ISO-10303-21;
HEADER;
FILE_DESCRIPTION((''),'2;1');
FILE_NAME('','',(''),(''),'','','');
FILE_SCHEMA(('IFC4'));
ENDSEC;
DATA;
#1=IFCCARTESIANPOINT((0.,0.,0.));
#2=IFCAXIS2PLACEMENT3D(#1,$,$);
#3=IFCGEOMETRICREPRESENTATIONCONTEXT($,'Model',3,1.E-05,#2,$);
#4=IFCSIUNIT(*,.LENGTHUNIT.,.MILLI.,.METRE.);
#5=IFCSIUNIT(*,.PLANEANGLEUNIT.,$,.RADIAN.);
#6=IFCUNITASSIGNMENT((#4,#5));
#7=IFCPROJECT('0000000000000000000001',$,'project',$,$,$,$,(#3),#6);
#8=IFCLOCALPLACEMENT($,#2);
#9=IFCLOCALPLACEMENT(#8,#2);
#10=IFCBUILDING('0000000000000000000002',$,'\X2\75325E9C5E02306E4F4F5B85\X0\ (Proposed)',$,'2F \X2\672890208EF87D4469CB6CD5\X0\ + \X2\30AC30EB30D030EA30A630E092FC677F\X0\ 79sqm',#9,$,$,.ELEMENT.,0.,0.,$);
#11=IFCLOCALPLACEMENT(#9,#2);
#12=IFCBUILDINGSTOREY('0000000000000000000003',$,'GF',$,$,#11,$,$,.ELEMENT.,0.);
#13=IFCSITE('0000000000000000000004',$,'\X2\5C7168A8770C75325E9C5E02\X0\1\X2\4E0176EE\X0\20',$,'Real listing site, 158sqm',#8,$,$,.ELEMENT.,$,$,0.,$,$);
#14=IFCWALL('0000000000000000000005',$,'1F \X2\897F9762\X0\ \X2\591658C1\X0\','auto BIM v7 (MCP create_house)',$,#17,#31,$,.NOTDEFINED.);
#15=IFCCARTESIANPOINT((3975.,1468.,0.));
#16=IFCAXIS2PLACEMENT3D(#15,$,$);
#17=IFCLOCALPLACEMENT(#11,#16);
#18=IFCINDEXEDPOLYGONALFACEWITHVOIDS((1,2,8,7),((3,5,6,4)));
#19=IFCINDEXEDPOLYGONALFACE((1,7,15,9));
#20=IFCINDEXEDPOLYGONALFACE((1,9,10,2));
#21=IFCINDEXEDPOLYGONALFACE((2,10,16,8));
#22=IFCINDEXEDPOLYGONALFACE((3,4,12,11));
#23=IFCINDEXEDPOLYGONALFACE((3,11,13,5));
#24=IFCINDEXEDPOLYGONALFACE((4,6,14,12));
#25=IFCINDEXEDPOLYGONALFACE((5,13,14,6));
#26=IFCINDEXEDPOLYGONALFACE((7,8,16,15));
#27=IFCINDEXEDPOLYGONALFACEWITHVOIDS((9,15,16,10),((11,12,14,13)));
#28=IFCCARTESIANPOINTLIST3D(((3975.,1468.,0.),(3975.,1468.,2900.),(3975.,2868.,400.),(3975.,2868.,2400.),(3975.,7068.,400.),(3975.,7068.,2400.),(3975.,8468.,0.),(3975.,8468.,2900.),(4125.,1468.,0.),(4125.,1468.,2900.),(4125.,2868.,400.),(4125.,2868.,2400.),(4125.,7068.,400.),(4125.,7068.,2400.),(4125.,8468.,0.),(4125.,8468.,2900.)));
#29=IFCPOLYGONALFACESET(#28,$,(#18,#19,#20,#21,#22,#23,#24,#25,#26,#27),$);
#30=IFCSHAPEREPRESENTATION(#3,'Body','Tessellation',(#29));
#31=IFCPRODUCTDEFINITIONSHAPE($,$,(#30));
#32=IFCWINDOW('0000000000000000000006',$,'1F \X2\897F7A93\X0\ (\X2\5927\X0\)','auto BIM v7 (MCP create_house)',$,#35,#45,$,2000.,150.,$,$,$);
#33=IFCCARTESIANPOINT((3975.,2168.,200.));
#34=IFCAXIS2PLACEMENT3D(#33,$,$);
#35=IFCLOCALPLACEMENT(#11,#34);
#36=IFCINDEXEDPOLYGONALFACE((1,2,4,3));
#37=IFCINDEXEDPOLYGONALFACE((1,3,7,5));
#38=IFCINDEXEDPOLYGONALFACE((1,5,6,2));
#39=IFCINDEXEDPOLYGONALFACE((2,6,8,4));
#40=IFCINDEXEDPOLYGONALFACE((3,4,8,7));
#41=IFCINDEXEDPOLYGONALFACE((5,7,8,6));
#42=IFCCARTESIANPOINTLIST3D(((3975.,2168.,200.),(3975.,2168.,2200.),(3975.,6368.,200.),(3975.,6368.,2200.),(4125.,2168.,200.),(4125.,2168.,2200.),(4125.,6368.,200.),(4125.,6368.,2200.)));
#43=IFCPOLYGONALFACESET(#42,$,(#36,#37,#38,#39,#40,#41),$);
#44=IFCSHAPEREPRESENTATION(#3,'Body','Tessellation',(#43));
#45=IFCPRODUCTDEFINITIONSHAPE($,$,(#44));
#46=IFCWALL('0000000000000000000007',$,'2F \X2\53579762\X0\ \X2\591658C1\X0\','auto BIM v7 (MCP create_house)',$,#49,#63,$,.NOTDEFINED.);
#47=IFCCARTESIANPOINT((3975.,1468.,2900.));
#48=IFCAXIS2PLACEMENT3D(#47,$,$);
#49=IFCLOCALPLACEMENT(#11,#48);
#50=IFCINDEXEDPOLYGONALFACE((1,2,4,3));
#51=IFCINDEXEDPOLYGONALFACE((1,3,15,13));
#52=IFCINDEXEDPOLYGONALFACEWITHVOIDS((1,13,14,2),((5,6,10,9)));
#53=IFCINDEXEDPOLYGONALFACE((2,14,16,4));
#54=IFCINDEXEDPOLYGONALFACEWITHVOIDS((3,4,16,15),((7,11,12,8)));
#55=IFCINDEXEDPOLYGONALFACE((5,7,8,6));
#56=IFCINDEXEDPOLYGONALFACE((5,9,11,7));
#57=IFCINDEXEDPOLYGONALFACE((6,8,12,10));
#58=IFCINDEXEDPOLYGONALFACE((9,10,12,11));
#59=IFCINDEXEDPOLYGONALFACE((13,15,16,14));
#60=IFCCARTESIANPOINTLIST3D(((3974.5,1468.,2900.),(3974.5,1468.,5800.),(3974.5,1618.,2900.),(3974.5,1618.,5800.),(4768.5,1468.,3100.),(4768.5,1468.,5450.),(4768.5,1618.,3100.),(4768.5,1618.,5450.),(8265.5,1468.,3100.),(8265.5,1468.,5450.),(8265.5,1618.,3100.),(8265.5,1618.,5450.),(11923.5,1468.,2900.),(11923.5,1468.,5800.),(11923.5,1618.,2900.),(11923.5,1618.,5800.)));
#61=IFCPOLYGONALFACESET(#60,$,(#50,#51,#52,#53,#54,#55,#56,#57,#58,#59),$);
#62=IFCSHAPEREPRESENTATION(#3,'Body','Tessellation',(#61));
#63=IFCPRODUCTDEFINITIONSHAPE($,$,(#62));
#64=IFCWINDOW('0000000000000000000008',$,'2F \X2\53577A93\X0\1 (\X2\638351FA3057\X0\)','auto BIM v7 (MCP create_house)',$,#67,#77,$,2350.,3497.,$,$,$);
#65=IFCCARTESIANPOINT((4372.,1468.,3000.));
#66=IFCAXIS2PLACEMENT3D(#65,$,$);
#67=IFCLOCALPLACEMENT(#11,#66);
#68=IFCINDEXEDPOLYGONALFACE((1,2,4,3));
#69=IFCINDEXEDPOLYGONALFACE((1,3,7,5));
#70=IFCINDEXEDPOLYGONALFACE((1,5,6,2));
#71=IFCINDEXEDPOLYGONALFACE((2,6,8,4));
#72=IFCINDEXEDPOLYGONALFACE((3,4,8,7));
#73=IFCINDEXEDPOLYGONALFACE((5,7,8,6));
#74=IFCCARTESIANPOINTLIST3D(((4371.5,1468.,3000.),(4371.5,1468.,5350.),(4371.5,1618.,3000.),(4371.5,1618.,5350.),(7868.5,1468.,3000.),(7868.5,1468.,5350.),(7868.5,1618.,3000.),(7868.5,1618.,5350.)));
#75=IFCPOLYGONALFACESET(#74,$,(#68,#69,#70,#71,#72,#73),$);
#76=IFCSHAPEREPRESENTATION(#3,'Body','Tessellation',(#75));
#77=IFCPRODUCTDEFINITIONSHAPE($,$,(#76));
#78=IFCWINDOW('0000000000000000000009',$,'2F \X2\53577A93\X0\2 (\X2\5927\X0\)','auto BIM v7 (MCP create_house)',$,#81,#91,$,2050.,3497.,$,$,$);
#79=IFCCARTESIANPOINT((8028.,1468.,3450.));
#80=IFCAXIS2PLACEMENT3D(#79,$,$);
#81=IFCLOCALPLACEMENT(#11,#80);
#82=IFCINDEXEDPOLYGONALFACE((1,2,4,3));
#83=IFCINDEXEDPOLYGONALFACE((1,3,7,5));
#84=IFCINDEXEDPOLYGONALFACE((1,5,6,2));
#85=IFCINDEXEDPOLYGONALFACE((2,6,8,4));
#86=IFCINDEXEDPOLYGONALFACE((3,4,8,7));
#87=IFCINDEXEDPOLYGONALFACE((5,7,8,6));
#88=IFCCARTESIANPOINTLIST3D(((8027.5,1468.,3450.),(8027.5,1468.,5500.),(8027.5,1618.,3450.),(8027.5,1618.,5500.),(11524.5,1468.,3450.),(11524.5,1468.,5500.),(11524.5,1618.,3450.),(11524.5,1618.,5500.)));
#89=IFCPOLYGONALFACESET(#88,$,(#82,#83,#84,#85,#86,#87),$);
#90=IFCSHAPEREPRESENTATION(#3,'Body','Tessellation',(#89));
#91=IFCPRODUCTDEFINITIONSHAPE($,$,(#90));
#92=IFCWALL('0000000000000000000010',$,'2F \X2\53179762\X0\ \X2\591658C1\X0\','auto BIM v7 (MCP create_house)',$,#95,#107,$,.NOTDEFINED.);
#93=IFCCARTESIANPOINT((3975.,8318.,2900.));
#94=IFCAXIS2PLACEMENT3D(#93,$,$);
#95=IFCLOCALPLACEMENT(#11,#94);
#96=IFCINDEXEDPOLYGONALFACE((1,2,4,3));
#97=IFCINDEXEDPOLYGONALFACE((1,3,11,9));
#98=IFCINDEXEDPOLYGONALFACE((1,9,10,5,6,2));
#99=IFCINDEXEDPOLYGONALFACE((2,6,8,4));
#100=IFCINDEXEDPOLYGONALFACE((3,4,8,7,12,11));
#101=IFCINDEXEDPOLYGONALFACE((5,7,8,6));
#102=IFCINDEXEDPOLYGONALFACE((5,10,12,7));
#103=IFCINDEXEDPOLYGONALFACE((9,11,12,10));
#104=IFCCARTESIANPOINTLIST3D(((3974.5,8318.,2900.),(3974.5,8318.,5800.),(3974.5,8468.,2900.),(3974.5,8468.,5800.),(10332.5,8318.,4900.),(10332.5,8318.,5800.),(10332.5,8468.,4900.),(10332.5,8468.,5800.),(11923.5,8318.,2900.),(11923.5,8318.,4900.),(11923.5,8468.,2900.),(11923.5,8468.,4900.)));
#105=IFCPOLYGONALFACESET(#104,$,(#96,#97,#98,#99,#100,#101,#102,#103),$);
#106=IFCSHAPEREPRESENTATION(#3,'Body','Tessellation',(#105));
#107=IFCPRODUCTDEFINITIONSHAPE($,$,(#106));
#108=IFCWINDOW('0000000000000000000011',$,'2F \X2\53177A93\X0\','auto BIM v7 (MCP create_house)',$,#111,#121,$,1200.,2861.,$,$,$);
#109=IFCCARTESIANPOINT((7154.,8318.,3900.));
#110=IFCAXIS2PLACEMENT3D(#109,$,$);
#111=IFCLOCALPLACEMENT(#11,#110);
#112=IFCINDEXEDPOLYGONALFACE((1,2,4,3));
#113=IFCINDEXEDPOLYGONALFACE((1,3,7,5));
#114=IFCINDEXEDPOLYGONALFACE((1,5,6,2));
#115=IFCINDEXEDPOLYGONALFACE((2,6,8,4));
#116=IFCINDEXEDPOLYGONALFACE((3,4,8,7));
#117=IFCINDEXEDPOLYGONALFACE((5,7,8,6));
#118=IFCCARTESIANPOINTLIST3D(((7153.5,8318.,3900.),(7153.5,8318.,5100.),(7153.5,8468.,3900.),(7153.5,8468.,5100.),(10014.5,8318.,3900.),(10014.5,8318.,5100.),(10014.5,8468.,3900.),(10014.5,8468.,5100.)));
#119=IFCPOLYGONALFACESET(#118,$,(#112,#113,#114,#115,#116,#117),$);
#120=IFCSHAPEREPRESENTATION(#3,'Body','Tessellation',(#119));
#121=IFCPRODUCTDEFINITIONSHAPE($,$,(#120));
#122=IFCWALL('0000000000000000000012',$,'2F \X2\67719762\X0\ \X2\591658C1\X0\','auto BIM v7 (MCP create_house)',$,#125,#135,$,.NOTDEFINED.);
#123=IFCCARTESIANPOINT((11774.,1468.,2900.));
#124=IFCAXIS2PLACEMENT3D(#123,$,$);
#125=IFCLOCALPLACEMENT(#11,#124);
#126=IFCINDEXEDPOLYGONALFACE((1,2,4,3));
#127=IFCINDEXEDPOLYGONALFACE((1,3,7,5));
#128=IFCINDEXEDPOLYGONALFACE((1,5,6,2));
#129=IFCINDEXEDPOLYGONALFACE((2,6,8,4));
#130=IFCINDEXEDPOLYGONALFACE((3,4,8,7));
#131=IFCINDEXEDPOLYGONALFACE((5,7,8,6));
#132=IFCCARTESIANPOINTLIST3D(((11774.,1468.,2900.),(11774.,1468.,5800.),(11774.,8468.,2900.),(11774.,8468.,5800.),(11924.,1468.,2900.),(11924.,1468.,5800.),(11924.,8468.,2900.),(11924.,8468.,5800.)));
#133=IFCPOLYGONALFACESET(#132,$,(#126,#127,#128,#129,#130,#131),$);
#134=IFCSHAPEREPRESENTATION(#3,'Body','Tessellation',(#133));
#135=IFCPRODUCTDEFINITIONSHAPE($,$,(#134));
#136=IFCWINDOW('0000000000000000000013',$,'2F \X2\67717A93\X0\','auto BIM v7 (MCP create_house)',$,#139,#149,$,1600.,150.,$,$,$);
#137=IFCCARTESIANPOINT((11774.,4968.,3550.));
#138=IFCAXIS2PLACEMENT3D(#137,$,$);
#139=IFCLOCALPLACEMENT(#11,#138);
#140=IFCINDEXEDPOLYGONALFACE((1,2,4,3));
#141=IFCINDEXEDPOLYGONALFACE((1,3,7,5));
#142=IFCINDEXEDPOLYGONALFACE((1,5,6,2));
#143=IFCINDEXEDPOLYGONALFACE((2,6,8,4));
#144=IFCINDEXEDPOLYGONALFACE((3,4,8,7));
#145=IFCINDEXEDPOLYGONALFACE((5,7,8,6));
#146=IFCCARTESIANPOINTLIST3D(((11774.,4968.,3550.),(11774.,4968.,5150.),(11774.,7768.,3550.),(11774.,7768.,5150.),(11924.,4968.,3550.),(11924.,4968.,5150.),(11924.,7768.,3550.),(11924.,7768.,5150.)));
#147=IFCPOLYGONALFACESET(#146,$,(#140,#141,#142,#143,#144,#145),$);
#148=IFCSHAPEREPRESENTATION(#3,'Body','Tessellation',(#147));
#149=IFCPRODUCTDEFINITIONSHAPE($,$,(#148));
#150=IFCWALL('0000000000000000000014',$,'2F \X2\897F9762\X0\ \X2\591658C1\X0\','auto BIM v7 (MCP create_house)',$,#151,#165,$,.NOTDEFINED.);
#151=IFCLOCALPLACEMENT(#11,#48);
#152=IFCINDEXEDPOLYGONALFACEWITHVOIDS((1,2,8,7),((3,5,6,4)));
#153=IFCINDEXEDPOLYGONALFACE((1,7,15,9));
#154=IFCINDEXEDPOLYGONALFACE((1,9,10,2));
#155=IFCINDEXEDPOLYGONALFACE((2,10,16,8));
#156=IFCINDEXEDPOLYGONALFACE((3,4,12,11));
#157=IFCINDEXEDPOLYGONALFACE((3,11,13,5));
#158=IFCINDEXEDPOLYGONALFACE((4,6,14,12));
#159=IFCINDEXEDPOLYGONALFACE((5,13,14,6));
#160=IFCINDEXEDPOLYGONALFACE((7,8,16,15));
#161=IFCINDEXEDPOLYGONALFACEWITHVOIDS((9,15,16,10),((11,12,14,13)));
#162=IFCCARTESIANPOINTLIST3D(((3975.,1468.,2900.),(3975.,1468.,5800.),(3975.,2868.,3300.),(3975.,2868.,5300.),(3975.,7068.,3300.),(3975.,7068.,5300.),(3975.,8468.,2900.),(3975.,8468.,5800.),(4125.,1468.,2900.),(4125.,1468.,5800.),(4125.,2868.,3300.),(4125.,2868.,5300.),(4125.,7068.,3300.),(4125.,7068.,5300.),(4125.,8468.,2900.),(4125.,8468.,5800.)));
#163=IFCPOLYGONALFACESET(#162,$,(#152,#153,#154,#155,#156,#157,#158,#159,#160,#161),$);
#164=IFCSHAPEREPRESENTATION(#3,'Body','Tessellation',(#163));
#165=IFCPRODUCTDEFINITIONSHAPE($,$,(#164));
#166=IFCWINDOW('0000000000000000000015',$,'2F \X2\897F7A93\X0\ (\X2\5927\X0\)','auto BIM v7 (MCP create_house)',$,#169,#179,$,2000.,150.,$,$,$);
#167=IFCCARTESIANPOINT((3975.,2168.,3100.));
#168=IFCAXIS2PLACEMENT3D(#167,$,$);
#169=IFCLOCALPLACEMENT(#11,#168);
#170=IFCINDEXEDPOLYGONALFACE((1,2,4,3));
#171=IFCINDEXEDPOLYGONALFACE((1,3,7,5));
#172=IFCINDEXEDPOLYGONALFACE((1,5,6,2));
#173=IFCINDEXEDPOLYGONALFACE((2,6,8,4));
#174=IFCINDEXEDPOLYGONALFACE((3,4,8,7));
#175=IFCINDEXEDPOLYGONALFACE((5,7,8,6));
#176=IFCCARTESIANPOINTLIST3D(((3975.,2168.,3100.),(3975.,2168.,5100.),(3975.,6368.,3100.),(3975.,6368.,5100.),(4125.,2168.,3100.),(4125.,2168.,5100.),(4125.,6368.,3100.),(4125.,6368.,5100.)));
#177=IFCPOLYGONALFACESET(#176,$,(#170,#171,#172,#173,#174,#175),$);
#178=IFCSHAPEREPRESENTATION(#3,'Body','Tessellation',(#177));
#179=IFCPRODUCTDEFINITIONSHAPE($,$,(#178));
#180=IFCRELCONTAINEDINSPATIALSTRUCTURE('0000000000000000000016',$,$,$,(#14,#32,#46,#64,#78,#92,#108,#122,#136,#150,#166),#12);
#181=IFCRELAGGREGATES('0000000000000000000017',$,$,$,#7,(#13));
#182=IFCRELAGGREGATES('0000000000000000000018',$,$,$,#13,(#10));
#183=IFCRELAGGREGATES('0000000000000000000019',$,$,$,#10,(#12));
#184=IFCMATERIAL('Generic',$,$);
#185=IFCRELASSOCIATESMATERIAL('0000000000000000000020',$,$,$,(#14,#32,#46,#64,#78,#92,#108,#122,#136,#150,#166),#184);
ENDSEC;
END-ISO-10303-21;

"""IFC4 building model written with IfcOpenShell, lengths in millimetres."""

from ifc_helpers import new_model, si_unit, frame, frame_2d, origin, place, context, project, spatial, rectangle, extrude, material, element, fill, save


model = new_model("IFC4")

# Units and contexts
model_context = context("Model", 3, precision=1e-05, world=origin())
ifc_project = project(units=[si_unit("LENGTHUNIT", "METRE", prefix="MILLI"), si_unit("PLANEANGLEUNIT", "RADIAN")], contexts=[model_context])

# Site, building, storey
site_placement = place(None, origin())
site = spatial("IfcSite", under=ifc_project, at=site_placement, Name="山梨県甲府市1丁目20", ObjectType="Real listing site, 158sqm", CompositionType="ELEMENT", RefElevation=0.0)
building_placement = place(site_placement, origin())
building = spatial("IfcBuilding", under=site, at=building_placement, Name="甲府市の住宅 (Proposed)", ObjectType="2F 木造軸組構法 + ガルバリウム鋼板 79sqm", CompositionType="ELEMENT", ElevationOfRefHeight=0.0, ElevationOfTerrain=0.0)
storey_placement = place(building_placement, origin())
storey = spatial("IfcBuildingStorey", under=building, at=storey_placement, Name="GF", CompositionType="ELEMENT", Elevation=0.0)

# Shared definitions
ifc_material = material(Name="Generic")

# Wall, opening, window
wall_1_placement = place(storey_placement, frame((3975.0, 1468.0, 0.0)))
wall_1 = element("IfcWall", 1, at=wall_1_placement, inside=storey, material=ifc_material, Name="1F 西面 外壁", Description="auto BIM v7 (MCP create_house)", PredefinedType="NOTDEFINED", context=model_context, shape_type="SweptSolid", body=[
    extrude(rectangle(XDim=150.0, YDim=7000.0, at=frame_2d((75.0, 3500.0))), frame((3975.0, 1468.0, 0.0)), (0.0, 0.0, 1.0), 2900.0),
])
opening_1_placement = place(storey_placement, frame((3975.0, 2168.0, 200.0)))
opening_1 = element("IfcOpeningElement", 2, at=opening_1_placement, cuts=wall_1, PredefinedType="NOTDEFINED", context=model_context, shape_type="SweptSolid", body=[
    extrude(rectangle(XDim=150.0, YDim=4200.0, at=frame_2d((75.0, 2100.0))), frame((3975.0, 2168.0, 200.0)), (0.0, 0.0, 1.0), 2000.0),
])
window_1_placement = place(storey_placement, frame((3975.0, 2168.0, 200.0)))
window_1 = element("IfcWindow", 3, at=window_1_placement, inside=storey, material=ifc_material, Name="1F 西窓 (大)", Description="auto BIM v7 (MCP create_house)", OverallHeight=2000.0, OverallWidth=150.0, context=model_context, shape_type="SweptSolid", body=[
    extrude(rectangle(XDim=150.0, YDim=4200.0, at=frame_2d((75.0, 2100.0))), frame((3975.0, 2168.0, 200.0)), (0.0, 0.0, 1.0), 2000.0),
])
fill(opening_1, window_1)

# Wall, openings, windows
wall_2_placement = place(storey_placement, frame((3975.0, 1468.0, 2900.0)))
wall_2 = element("IfcWall", 4, at=wall_2_placement, inside=storey, material=ifc_material, Name="2F 南面 外壁", Description="auto BIM v7 (MCP create_house)", PredefinedType="NOTDEFINED", context=model_context, shape_type="SweptSolid", body=[
    extrude(rectangle(XDim=7949.0, YDim=150.0, at=frame_2d((3974.0, 75.0))), frame((3975.0, 1468.0, 2900.0)), (0.0, 0.0, 1.0), 2900.0),
])
opening_2_placement = place(storey_placement, frame((4372.0, 1468.0, 3000.0)))
opening_2 = element("IfcOpeningElement", 5, at=opening_2_placement, cuts=wall_2, PredefinedType="NOTDEFINED", context=model_context, shape_type="SweptSolid", body=[
    extrude(rectangle(XDim=3497.0, YDim=150.0, at=frame_2d((1748.0, 75.0))), frame((4372.0, 1468.0, 3000.0)), (0.0, 0.0, 1.0), 2350.0),
])
opening_3_placement = place(storey_placement, frame((8028.0, 1468.0, 3450.0)))
opening_3 = element("IfcOpeningElement", 6, at=opening_3_placement, cuts=wall_2, PredefinedType="NOTDEFINED", context=model_context, shape_type="SweptSolid", body=[
    extrude(rectangle(XDim=3497.0, YDim=150.0, at=frame_2d((1748.0, 75.0))), frame((8028.0, 1468.0, 3450.0)), (0.0, 0.0, 1.0), 2050.0),
])
window_2_placement = place(storey_placement, frame((4372.0, 1468.0, 3000.0)))
window_2 = element("IfcWindow", 7, at=window_2_placement, inside=storey, material=ifc_material, Name="2F 南窓1 (掃出し)", Description="auto BIM v7 (MCP create_house)", OverallHeight=2350.0, OverallWidth=3497.0, context=model_context, shape_type="SweptSolid", body=[
    extrude(rectangle(XDim=3497.0, YDim=150.0, at=frame_2d((1748.0, 75.0))), frame((4372.0, 1468.0, 3000.0)), (0.0, 0.0, 1.0), 2350.0),
])
fill(opening_2, window_2)
window_3_placement = place(storey_placement, frame((8028.0, 1468.0, 3450.0)))
window_3 = element("IfcWindow", 8, at=window_3_placement, inside=storey, material=ifc_material, Name="2F 南窓2 (大)", Description="auto BIM v7 (MCP create_house)", OverallHeight=2050.0, OverallWidth=3497.0, context=model_context, shape_type="SweptSolid", body=[
    extrude(rectangle(XDim=3497.0, YDim=150.0, at=frame_2d((1748.0, 75.0))), frame((8028.0, 1468.0, 3450.0)), (0.0, 0.0, 1.0), 2050.0),
])
fill(opening_3, window_3)

# Walls, openings, windows
wall_3_placement = place(storey_placement, frame((3975.0, 8318.0, 2900.0)))
wall_3 = element("IfcWall", 9, at=wall_3_placement, inside=storey, material=ifc_material, Name="2F 北面 外壁", Description="auto BIM v7 (MCP create_house)", PredefinedType="NOTDEFINED", context=model_context, shape_type="SweptSolid", body=[
    extrude(rectangle(XDim=7949.0, YDim=150.0, at=frame_2d((3974.0, 75.0))), frame((3975.0, 8318.0, 2900.0)), (0.0, 0.0, 1.0), 2900.0),
])
opening_4_placement = place(storey_placement, frame((7154.0, 8318.0, 3900.0)))
opening_4 = element("IfcOpeningElement", 10, at=opening_4_placement, cuts=wall_3, PredefinedType="NOTDEFINED", context=model_context, shape_type="SweptSolid", body=[
    extrude(rectangle(XDim=2861.0, YDim=150.0, at=frame_2d((1430.0, 75.0))), frame((7154.0, 8318.0, 3900.0)), (0.0, 0.0, 1.0), 1200.0),
])
window_4_placement = place(storey_placement, frame((7154.0, 8318.0, 3900.0)))
window_4 = element("IfcWindow", 11, at=window_4_placement, inside=storey, material=ifc_material, Name="2F 北窓", Description="auto BIM v7 (MCP create_house)", OverallHeight=1200.0, OverallWidth=2861.0, context=model_context, shape_type="SweptSolid", body=[
    extrude(rectangle(XDim=2861.0, YDim=150.0, at=frame_2d((1430.0, 75.0))), frame((7154.0, 8318.0, 3900.0)), (0.0, 0.0, 1.0), 1200.0),
])
fill(opening_4, window_4)
wall_4_placement = place(storey_placement, frame((11774.0, 1468.0, 2900.0)))
wall_4 = element("IfcWall", 12, at=wall_4_placement, inside=storey, material=ifc_material, Name="2F 東面 外壁", Description="auto BIM v7 (MCP create_house)", PredefinedType="NOTDEFINED", context=model_context, shape_type="SweptSolid", body=[
    extrude(rectangle(XDim=150.0, YDim=7000.0, at=frame_2d((75.0, 3500.0))), frame((11774.0, 1468.0, 2900.0)), (0.0, 0.0, 1.0), 2900.0),
])
opening_5_placement = place(storey_placement, frame((11774.0, 4968.0, 3550.0)))
opening_5 = element("IfcOpeningElement", 13, at=opening_5_placement, cuts=wall_4, PredefinedType="NOTDEFINED", context=model_context, shape_type="SweptSolid", body=[
    extrude(rectangle(XDim=150.0, YDim=2800.0, at=frame_2d((75.0, 1400.0))), frame((11774.0, 4968.0, 3550.0)), (0.0, 0.0, 1.0), 1600.0),
])
window_5_placement = place(storey_placement, frame((11774.0, 4968.0, 3550.0)))
window_5 = element("IfcWindow", 14, at=window_5_placement, inside=storey, material=ifc_material, Name="2F 東窓", Description="auto BIM v7 (MCP create_house)", OverallHeight=1600.0, OverallWidth=150.0, context=model_context, shape_type="SweptSolid", body=[
    extrude(rectangle(XDim=150.0, YDim=2800.0, at=frame_2d((75.0, 1400.0))), frame((11774.0, 4968.0, 3550.0)), (0.0, 0.0, 1.0), 1600.0),
])
fill(opening_5, window_5)
wall_5_placement = place(storey_placement, frame((3975.0, 1468.0, 2900.0)))
wall_5 = element("IfcWall", 15, at=wall_5_placement, inside=storey, material=ifc_material, Name="2F 西面 外壁", Description="auto BIM v7 (MCP create_house)", PredefinedType="NOTDEFINED", context=model_context, shape_type="SweptSolid", body=[
    extrude(rectangle(XDim=150.0, YDim=7000.0, at=frame_2d((75.0, 3500.0))), frame((3975.0, 1468.0, 2900.0)), (0.0, 0.0, 1.0), 2900.0),
])
opening_6_placement = place(storey_placement, frame((3975.0, 2168.0, 3100.0)))
opening_6 = element("IfcOpeningElement", 16, at=opening_6_placement, cuts=wall_5, PredefinedType="NOTDEFINED", context=model_context, shape_type="SweptSolid", body=[
    extrude(rectangle(XDim=150.0, YDim=4200.0, at=frame_2d((75.0, 2100.0))), frame((3975.0, 2168.0, 3100.0)), (0.0, 0.0, 1.0), 2000.0),
])
window_6_placement = place(storey_placement, frame((3975.0, 2168.0, 3100.0)))
window_6 = element("IfcWindow", 17, at=window_6_placement, inside=storey, material=ifc_material, Name="2F 西窓 (大)", Description="auto BIM v7 (MCP create_house)", OverallHeight=2000.0, OverallWidth=150.0, context=model_context, shape_type="SweptSolid", body=[
    extrude(rectangle(XDim=150.0, YDim=4200.0, at=frame_2d((75.0, 2100.0))), frame((3975.0, 2168.0, 3100.0)), (0.0, 0.0, 1.0), 2000.0),
])
fill(opening_6, window_6)

save(model, "model.ifc")
